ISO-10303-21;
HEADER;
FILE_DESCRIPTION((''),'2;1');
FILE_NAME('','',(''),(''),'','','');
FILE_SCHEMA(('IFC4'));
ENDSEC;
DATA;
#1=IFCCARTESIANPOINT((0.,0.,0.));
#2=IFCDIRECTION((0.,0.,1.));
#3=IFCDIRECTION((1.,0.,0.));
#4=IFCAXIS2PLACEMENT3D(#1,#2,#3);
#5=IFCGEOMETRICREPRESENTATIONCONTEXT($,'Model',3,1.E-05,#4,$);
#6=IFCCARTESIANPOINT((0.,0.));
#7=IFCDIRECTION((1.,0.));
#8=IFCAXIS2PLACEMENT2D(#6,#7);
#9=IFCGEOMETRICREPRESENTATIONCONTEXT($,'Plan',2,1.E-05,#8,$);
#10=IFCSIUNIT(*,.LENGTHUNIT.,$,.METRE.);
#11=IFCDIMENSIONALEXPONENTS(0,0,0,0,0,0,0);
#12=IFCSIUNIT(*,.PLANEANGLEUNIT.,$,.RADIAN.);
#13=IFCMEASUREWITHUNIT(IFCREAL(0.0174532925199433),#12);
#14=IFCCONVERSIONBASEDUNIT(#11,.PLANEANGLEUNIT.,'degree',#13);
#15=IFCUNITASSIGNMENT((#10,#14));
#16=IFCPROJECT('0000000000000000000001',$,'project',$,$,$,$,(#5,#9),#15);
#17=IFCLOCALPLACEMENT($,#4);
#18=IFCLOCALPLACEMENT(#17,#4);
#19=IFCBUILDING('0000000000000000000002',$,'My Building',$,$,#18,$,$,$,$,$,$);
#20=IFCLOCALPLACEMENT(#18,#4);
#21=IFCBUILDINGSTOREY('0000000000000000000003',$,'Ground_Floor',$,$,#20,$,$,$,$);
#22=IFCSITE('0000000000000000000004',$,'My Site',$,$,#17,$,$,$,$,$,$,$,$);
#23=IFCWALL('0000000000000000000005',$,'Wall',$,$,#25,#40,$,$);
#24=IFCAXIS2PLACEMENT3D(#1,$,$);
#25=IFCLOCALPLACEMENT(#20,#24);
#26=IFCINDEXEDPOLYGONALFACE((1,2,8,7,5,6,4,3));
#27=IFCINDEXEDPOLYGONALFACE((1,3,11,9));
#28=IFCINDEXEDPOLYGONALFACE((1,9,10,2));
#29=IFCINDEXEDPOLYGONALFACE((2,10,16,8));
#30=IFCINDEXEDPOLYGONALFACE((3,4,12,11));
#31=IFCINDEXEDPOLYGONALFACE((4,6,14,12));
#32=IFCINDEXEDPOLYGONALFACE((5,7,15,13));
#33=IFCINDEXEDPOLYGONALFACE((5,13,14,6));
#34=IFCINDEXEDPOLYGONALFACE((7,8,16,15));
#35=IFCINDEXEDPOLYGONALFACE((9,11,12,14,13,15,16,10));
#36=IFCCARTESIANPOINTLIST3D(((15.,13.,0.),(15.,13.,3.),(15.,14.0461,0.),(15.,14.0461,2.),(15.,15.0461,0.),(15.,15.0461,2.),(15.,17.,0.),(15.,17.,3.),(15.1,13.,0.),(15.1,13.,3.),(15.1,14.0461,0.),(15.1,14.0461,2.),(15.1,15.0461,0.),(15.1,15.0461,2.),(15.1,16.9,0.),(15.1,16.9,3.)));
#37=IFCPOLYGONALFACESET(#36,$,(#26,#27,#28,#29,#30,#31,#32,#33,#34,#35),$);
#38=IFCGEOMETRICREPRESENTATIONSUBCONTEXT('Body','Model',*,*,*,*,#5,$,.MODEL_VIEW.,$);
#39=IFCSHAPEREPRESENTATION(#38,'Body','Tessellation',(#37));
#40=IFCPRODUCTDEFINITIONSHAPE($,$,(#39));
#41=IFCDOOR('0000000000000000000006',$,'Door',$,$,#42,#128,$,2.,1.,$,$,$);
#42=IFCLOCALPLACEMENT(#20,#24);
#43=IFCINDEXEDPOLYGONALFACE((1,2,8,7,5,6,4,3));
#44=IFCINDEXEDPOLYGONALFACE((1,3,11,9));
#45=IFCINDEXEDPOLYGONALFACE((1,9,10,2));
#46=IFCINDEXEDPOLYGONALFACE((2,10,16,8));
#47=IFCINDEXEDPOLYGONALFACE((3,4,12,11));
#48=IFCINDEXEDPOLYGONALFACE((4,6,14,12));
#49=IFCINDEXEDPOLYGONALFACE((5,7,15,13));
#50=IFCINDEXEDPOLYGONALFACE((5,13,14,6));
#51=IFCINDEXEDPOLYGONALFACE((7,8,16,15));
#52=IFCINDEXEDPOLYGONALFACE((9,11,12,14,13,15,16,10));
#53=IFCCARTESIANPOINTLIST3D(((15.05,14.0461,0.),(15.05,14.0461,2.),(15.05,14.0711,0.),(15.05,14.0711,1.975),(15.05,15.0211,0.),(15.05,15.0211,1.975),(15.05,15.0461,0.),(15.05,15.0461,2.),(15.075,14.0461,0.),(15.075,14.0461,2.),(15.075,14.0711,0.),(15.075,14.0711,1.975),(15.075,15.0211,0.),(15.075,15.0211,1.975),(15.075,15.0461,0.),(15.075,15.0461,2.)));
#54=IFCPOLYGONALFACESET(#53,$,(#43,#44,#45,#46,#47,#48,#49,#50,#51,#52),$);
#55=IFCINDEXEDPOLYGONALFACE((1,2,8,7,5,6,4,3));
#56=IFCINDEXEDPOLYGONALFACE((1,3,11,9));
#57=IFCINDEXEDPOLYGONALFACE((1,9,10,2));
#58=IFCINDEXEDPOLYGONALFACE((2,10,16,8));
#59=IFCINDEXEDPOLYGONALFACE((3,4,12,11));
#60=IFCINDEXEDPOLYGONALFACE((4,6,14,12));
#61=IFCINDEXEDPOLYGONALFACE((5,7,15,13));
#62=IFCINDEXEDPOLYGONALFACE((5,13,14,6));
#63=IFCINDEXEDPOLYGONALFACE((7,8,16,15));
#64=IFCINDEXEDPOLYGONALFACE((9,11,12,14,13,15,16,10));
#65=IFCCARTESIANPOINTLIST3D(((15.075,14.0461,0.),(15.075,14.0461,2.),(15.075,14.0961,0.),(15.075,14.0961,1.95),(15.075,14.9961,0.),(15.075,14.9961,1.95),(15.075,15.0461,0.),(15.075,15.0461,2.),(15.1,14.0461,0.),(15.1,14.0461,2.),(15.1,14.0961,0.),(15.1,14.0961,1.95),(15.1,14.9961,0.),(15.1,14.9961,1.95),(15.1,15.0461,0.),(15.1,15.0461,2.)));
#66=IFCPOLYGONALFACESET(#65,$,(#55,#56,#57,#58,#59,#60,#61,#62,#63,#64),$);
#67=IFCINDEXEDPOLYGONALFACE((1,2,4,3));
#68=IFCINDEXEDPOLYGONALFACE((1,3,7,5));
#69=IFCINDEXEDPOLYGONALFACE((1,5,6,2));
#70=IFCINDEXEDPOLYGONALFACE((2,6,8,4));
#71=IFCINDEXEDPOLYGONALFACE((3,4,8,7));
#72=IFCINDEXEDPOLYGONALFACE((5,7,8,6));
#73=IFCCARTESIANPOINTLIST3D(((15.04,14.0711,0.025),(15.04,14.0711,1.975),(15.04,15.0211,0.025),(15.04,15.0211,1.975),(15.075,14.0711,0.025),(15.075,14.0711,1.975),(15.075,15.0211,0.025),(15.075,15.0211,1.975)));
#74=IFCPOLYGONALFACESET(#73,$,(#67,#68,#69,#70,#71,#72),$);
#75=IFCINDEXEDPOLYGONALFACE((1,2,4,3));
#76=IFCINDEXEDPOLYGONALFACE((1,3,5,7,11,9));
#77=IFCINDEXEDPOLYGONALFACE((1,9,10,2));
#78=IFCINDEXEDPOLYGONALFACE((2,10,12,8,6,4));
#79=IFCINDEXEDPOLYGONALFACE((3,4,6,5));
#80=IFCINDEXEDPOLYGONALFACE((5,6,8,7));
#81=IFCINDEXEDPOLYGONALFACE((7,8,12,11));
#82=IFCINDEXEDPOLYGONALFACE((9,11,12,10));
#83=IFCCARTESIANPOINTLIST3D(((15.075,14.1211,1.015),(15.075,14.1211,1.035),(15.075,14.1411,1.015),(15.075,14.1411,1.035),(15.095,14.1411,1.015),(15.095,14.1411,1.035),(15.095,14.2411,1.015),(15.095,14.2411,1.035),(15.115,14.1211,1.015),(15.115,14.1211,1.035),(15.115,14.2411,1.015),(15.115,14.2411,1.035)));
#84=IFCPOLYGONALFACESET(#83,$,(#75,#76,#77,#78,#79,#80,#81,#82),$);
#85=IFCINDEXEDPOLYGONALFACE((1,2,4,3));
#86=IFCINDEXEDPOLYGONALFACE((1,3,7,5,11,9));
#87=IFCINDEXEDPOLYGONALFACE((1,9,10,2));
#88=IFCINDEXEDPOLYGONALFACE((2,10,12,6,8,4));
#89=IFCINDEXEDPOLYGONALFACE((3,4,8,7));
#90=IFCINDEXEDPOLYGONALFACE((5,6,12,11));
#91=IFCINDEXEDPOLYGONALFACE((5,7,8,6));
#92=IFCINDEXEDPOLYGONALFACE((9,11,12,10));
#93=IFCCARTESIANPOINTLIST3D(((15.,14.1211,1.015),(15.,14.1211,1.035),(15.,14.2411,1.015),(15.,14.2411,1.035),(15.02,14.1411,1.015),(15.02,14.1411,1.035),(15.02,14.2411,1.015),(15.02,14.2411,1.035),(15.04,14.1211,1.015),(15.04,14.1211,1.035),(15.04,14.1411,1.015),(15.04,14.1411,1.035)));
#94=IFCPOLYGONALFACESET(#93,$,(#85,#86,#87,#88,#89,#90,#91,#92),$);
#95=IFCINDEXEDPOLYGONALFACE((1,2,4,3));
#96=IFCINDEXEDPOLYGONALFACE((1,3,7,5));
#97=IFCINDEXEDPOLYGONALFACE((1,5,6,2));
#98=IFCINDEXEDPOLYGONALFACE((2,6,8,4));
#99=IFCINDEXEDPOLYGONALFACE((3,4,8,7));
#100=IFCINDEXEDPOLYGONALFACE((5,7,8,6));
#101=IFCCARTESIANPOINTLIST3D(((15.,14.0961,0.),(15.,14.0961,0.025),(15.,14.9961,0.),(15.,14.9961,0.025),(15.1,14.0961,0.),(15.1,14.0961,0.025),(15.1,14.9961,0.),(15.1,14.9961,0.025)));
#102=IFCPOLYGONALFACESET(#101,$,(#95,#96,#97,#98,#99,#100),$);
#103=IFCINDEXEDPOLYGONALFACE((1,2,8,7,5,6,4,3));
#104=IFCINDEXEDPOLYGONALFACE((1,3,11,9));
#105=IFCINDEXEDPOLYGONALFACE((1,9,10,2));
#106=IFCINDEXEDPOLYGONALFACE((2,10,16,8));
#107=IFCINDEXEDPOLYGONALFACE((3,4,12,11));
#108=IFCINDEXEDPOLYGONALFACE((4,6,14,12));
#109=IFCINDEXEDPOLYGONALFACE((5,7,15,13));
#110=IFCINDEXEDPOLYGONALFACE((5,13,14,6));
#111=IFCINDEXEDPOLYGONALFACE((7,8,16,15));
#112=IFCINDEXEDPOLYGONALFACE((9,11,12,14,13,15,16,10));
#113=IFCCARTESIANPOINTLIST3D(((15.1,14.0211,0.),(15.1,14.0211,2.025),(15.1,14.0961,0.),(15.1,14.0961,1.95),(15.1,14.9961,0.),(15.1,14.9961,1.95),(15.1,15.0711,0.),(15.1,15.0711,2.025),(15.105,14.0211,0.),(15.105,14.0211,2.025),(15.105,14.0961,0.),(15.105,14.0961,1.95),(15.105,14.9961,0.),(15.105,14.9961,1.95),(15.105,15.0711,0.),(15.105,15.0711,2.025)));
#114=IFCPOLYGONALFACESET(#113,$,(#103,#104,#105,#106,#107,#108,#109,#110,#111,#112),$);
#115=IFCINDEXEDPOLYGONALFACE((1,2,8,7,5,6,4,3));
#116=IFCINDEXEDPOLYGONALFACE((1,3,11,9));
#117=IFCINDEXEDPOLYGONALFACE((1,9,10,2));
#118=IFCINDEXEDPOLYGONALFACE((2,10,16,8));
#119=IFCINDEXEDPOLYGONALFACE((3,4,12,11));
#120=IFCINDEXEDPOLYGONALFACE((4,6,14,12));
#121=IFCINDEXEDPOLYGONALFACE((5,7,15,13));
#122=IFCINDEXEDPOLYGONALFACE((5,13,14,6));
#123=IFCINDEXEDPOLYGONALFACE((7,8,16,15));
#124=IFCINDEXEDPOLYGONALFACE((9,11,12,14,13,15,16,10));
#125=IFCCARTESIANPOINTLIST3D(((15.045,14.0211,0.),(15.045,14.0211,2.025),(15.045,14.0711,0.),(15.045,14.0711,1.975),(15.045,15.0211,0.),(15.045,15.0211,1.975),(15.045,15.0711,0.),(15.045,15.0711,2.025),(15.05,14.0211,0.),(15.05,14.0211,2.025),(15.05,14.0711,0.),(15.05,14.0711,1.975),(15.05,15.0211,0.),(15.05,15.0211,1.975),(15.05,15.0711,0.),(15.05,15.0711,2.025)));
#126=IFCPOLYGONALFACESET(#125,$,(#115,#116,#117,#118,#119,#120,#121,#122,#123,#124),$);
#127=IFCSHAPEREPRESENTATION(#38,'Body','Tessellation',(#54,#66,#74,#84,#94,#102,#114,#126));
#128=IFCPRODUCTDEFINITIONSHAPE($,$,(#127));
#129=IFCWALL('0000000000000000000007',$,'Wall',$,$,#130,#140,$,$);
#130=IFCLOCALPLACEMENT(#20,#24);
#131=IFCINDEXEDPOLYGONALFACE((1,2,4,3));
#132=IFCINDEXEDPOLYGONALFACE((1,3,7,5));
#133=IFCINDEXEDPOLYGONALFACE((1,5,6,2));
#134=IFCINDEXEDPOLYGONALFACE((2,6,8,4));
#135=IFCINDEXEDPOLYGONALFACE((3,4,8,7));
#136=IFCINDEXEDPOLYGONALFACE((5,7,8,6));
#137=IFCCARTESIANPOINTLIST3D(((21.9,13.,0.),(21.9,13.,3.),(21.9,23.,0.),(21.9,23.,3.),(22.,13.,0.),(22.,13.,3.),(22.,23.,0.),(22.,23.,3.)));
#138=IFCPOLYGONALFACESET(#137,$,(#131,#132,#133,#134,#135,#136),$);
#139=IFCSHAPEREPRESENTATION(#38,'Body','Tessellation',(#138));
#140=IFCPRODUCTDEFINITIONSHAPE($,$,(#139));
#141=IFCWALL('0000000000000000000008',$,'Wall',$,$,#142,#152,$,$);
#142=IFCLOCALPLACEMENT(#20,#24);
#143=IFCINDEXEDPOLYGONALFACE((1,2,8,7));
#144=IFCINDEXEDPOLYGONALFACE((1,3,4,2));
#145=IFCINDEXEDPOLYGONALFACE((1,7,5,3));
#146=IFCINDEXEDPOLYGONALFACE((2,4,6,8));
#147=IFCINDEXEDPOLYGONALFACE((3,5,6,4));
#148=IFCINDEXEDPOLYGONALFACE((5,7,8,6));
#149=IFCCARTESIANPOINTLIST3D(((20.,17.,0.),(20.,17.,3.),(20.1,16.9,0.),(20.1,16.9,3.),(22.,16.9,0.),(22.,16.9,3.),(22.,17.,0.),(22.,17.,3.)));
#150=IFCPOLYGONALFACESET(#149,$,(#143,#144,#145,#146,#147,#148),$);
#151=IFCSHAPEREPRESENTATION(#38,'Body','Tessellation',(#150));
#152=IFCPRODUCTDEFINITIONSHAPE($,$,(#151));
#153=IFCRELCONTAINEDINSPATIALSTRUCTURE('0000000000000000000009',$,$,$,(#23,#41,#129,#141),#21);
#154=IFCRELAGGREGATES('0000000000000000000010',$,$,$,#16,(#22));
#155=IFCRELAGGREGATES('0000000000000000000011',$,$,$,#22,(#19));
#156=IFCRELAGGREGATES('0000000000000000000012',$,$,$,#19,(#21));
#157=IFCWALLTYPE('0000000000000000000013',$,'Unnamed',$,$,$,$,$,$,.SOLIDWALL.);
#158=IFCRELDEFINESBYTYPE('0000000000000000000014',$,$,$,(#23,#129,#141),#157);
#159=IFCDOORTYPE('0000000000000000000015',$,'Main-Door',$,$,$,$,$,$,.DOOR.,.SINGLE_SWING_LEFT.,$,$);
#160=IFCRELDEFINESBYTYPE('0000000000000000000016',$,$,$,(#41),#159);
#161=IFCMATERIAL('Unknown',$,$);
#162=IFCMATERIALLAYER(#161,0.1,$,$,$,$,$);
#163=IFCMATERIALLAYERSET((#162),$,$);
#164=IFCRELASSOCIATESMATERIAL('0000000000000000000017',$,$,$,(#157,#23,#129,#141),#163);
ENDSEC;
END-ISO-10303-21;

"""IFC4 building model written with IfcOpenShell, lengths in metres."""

from ifc_helpers import new_model, entity, si_unit, converted_unit, frame, origin_with_axes, origin_2d_with_axis, place, context, subcontext, project, spatial, line, indexed_curve, outline, extrude, shape, source, transform, mapped, material, layer, layer_set, layer_usage, type_object, type_shapes, element, fill, save


model = new_model("IFC4")

# Units and contexts
model_context = context("Model", 3, precision=1e-05, world=origin_with_axes())
plan_context = context("Plan", 2, precision=1e-05, world=origin_2d_with_axis())
body_context_1 = subcontext(model_context, "Body", "Model", "MODEL_VIEW")
body_context_2 = subcontext(plan_context, "Body", "Plan", "PLAN_VIEW")
ifc_project = project(units=[si_unit("LENGTHUNIT", "METRE"), converted_unit("PLANEANGLEUNIT", "degree", entity("IfcReal", 0.0174532925199433), si_unit("PLANEANGLEUNIT", "RADIAN"), dimensions=[0, 0, 0, 0, 0, 0, 0])], contexts=[model_context, plan_context])

# Site, building, storey
site_placement = place(None, origin_with_axes())
site = spatial("IfcSite", under=ifc_project, at=site_placement, Name="My Site")
building_placement = place(site_placement, origin_with_axes())
building = spatial("IfcBuilding", under=site, at=building_placement, Name="My Building")
storey_placement = place(building_placement, origin_with_axes())
storey = spatial("IfcBuildingStorey", under=building, at=storey_placement, Name="Ground_Floor")

# Shared definitions
ifc_material = material(Name="Unknown")
ifc_layer = layer(ifc_material, 0.1)
ifc_layer_set = layer_set([ifc_layer])
wall_type = type_object("IfcWallType", Name="Unnamed", PredefinedType="SOLIDWALL", material=ifc_layer_set)

# Wall, opening, door
ifc_layer_usage_1 = layer_usage(ifc_layer_set, "AXIS2", "POSITIVE", 0.0)
wall_1_placement = place(storey_placement, frame((15.0, 17.0, 0.0), z_axis=(0.0, 0.0, 1.0), x_axis=(0.0, -1.0, 0.0)))
wall_1 = element("IfcWall", 1, at=wall_1_placement, inside=storey, type_object=wall_type, material=ifc_layer_usage_1, Name="Wall", context=body_context_1, shape_type="SweptSolid", body=[
    extrude(outline(indexed_curve([(0.0, 0.0), (0.1, 0.1), (4.0, 0.1), (4.0, 0.0)], segments=[line(1, 2, 3, 4, 1)])), origin_with_axes(), (0.0, 0.0, 1.0), 3.0),
])
shared_shape_1 = source(origin_with_axes(), body_context_1, "Body", "SweptSolid", [
    extrude(outline(indexed_curve([(0.0, 0.0), (1.0, 0.0), (1.0, 2.0), (0.0, 2.0)], segments=[line(1, 2, 3, 4, 1)])), frame((0.0, -0.6, 0.0), z_axis=(0.0, -1.0, 0.0), x_axis=(1.0, 0.0, 0.0)), (0.0, 0.0, -1.0), 1.2),
])
opening_1_placement = place(wall_1_placement, frame((2.9539, 0.1, 0.0), z_axis=(0.0, 0.0, 1.0), x_axis=(-1.0, 0.0, 0.0)))
opening_1 = element("IfcOpeningElement", 2, at=opening_1_placement, cuts=wall_1, PredefinedType="OPENING", context=body_context_1, shape_type="MappedRepresentation", body=[
    mapped(shared_shape_1, transform((0.0, 0.0, 0.0), x_axis=(1.0, 0.0, 0.0), y_axis=(0.0, 1.0, 0.0), z_axis=(0.0, 0.0, 1.0), scale=1.0)),
])
door_type_1 = type_object("IfcDoorType", Name="Main-Door", OperationType="SINGLE_SWING_LEFT", PredefinedType="DOOR")
shared_shape_2 = source(origin_with_axes(), body_context_1, "Body", "SweptSolid", [
    extrude(outline(indexed_curve([(0.0, 0.0), (0.0, 2.0), (1.0, 2.0), (1.0, 0.0), (0.975, 0.0), (0.975, 1.975), (0.025, 1.975), (0.025, 0.0)], segments=[line(1, 2, 3, 4, 5, 6, 7, 8, 1)])), frame((0.0, 0.025, 0.0), z_axis=(0.0, -1.0, 0.0), x_axis=(1.0, 0.0, 0.0)), (0.0, 0.0, -1.0), 0.025),
    extrude(outline(indexed_curve([(0.0, 0.0), (0.0, 2.0), (1.0, 2.0), (1.0, 0.0), (0.95, 0.0), (0.95, 1.95), (0.05, 1.95), (0.05, 0.0)], segments=[line(1, 2, 3, 4, 5, 6, 7, 8, 1)])), frame((0.0, 0.0, 0.0), z_axis=(0.0, -1.0, 0.0), x_axis=(1.0, 0.0, 0.0)), (0.0, 0.0, -1.0), 0.025),
    extrude(outline(indexed_curve([(0.0, 0.0), (0.95, 0.0), (0.95, 0.035), (0.0, 0.035)], segments=[line(1, 2, 3, 4, 1)])), frame((0.025, 0.025, 0.025), z_axis=(0.0, 0.0, 1.0), x_axis=(1.0, 0.0, 0.0)), (0.0, 0.0, 1.0), 1.95),
    extrude(outline(indexed_curve([(0.0, 0.0), (0.0, -0.04), (0.12, -0.04), (0.12, -0.02), (0.02, -0.02), (0.02, 0.0)], segments=[line(1, 2, 3, 4, 5, 6, 1)])), frame((0.075, 0.025, 1.015), z_axis=(0.0, 0.0, 1.0), x_axis=(1.0, 0.0, 0.0)), (0.0, 0.0, 1.0), 0.02),
    extrude(outline(indexed_curve([(0.0, 0.0), (0.0, 0.04), (0.12, 0.04), (0.12, 0.02), (0.02, 0.02), (0.02, 0.0)], segments=[line(1, 2, 3, 4, 5, 6, 1)])), frame((0.075, 0.06, 1.015), z_axis=(0.0, 0.0, 1.0), x_axis=(1.0, 0.0, 0.0)), (0.0, 0.0, 1.0), 0.02),
    extrude(outline(indexed_curve([(0.0, 0.0), (0.9, 0.0), (0.9, 0.1), (0.0, 0.1)], segments=[line(1, 2, 3, 4, 1)])), frame((0.05, 0.0, 0.0), z_axis=(0.0, 0.0, 1.0), x_axis=(1.0, 0.0, 0.0)), (0.0, 0.0, 1.0), 0.025),
    extrude(outline(indexed_curve([(0.0, 0.0), (0.0, 2.025), (1.05, 2.025), (1.05, 0.0), (0.975, 0.0), (0.975, 1.95), (0.075, 1.95), (0.075, 0.0)], segments=[line(1, 2, 3, 4, 5, 6, 7, 8, 1)])), frame((-0.025, -0.005, 0.0), z_axis=(0.0, -1.0, 0.0), x_axis=(1.0, 0.0, 0.0)), (0.0, 0.0, -1.0), 0.005),
    extrude(outline(indexed_curve([(0.0, 0.0), (0.0, 2.025), (1.05, 2.025), (1.05, 0.0), (1.0, 0.0), (1.0, 1.975), (0.05, 1.975), (0.05, 0.0)], segments=[line(1, 2, 3, 4, 5, 6, 7, 8, 1)])), frame((-0.025, 0.05, 0.0), z_axis=(0.0, -1.0, 0.0), x_axis=(1.0, 0.0, 0.0)), (0.0, 0.0, -1.0), 0.005),
])
shared_shape_3 = source(origin_with_axes(), body_context_2, "Body", "Curve2D", [
    entity("IfcIndexedPolyCurve", entity("IfcCartesianPointList2D", [[0.0, 0.0], [0.0, 0.05], [0.025, 0.05], [0.025, 0.025], [0.05, 0.025], [0.05, 0.0]]), [entity("IfcLineIndex", [1, 2, 3, 4, 5, 6, 1])]),
    entity("IfcIndexedPolyCurve", entity("IfcCartesianPointList2D", [[1.0, 0.0], [1.0, 0.05], [0.975, 0.05], [0.975, 0.025], [0.95, 0.025], [0.95, 0.0]]), [entity("IfcLineIndex", [1, 2, 3, 4, 5, 6, 1])]),
    entity("IfcTrimmedCurve", entity("IfcEllipse", entity("IfcAxis2Placement2D", entity("IfcCartesianPoint", [0.94, 0.05]), entity("IfcDirection", [1.0, 0.0])), 0.915, 0.95), [entity("IfcCartesianPoint", [0.94, 1.0])], [entity("IfcCartesianPoint", [0.025, 0.05])], True, "CARTESIAN"),
    entity("IfcIndexedPolyCurve", entity("IfcCartesianPointList2D", [[0.975, 0.05], [0.94, 0.05], [0.94, 1.0], [0.975, 1.0]]), [entity("IfcLineIndex", [1, 2, 3, 4, 1])]),
])
type_shapes(door_type_1, [shared_shape_2, shared_shape_3])
door_1_placement = place(opening_1_placement, frame((0.0, 0.0, 0.0), z_axis=(0.0, 0.0, 1.0), x_axis=(1.0, 0.0, 0.0)))
door_1 = element("IfcDoor", 3, at=door_1_placement, inside=storey, type_object=door_type_1, Name="Door", OverallHeight=2.0, OverallWidth=1.0, shapes=[
    shape(body_context_1, "Body", "MappedRepresentation", [mapped(shared_shape_2, transform((0.0, 0.0, 0.0), x_axis=(1.0, 0.0, 0.0), y_axis=(0.0, 1.0, 0.0), z_axis=(0.0, 0.0, 1.0), scale=1.0))]),
    shape(body_context_2, "Body", "MappedRepresentation", [mapped(shared_shape_3, transform((0.0, 0.0, 0.0), x_axis=(1.0, 0.0, 0.0), y_axis=(0.0, 1.0, 0.0), z_axis=(0.0, 0.0, 1.0), scale=1.0))]),
])
fill(opening_1, door_1)

# Walls
ifc_layer_usage_2 = layer_usage(ifc_layer_set, "AXIS2", "POSITIVE", 0.0)
wall_2_placement = place(storey_placement, frame((22.0, 13.0, 0.0), z_axis=(0.0, 0.0, 1.0), x_axis=(0.0, 1.0, 0.0)))
element("IfcWall", 4, at=wall_2_placement, inside=storey, type_object=wall_type, material=ifc_layer_usage_2, Name="Wall", context=body_context_1, shape_type="SweptSolid", body=[
    extrude(outline(indexed_curve([(0.0, 0.0), (0.0, 0.1), (10.0, 0.1), (10.0, 0.0)], segments=[line(1, 2, 3, 4, 1)])), origin_with_axes(), (0.0, 0.0, 1.0), 3.0),
])
ifc_layer_usage_3 = layer_usage(ifc_layer_set, "AXIS2", "POSITIVE", 0.0)
wall_3_placement = place(storey_placement, frame((22.0, 17.0, 0.0), z_axis=(0.0, 0.0, 1.0), x_axis=(-1.0, 0.0, 0.0)))
element("IfcWall", 5, at=wall_3_placement, inside=storey, type_object=wall_type, material=ifc_layer_usage_3, Name="Wall", context=body_context_1, shape_type="SweptSolid", body=[
    extrude(outline(indexed_curve([(0.0, 0.0), (0.0, 0.1), (1.9, 0.1), (2.0, 0.0)], segments=[line(1, 2, 3, 4, 1)])), origin_with_axes(), (0.0, 0.0, 1.0), 3.0),
])

save(model, "model.ifc")
